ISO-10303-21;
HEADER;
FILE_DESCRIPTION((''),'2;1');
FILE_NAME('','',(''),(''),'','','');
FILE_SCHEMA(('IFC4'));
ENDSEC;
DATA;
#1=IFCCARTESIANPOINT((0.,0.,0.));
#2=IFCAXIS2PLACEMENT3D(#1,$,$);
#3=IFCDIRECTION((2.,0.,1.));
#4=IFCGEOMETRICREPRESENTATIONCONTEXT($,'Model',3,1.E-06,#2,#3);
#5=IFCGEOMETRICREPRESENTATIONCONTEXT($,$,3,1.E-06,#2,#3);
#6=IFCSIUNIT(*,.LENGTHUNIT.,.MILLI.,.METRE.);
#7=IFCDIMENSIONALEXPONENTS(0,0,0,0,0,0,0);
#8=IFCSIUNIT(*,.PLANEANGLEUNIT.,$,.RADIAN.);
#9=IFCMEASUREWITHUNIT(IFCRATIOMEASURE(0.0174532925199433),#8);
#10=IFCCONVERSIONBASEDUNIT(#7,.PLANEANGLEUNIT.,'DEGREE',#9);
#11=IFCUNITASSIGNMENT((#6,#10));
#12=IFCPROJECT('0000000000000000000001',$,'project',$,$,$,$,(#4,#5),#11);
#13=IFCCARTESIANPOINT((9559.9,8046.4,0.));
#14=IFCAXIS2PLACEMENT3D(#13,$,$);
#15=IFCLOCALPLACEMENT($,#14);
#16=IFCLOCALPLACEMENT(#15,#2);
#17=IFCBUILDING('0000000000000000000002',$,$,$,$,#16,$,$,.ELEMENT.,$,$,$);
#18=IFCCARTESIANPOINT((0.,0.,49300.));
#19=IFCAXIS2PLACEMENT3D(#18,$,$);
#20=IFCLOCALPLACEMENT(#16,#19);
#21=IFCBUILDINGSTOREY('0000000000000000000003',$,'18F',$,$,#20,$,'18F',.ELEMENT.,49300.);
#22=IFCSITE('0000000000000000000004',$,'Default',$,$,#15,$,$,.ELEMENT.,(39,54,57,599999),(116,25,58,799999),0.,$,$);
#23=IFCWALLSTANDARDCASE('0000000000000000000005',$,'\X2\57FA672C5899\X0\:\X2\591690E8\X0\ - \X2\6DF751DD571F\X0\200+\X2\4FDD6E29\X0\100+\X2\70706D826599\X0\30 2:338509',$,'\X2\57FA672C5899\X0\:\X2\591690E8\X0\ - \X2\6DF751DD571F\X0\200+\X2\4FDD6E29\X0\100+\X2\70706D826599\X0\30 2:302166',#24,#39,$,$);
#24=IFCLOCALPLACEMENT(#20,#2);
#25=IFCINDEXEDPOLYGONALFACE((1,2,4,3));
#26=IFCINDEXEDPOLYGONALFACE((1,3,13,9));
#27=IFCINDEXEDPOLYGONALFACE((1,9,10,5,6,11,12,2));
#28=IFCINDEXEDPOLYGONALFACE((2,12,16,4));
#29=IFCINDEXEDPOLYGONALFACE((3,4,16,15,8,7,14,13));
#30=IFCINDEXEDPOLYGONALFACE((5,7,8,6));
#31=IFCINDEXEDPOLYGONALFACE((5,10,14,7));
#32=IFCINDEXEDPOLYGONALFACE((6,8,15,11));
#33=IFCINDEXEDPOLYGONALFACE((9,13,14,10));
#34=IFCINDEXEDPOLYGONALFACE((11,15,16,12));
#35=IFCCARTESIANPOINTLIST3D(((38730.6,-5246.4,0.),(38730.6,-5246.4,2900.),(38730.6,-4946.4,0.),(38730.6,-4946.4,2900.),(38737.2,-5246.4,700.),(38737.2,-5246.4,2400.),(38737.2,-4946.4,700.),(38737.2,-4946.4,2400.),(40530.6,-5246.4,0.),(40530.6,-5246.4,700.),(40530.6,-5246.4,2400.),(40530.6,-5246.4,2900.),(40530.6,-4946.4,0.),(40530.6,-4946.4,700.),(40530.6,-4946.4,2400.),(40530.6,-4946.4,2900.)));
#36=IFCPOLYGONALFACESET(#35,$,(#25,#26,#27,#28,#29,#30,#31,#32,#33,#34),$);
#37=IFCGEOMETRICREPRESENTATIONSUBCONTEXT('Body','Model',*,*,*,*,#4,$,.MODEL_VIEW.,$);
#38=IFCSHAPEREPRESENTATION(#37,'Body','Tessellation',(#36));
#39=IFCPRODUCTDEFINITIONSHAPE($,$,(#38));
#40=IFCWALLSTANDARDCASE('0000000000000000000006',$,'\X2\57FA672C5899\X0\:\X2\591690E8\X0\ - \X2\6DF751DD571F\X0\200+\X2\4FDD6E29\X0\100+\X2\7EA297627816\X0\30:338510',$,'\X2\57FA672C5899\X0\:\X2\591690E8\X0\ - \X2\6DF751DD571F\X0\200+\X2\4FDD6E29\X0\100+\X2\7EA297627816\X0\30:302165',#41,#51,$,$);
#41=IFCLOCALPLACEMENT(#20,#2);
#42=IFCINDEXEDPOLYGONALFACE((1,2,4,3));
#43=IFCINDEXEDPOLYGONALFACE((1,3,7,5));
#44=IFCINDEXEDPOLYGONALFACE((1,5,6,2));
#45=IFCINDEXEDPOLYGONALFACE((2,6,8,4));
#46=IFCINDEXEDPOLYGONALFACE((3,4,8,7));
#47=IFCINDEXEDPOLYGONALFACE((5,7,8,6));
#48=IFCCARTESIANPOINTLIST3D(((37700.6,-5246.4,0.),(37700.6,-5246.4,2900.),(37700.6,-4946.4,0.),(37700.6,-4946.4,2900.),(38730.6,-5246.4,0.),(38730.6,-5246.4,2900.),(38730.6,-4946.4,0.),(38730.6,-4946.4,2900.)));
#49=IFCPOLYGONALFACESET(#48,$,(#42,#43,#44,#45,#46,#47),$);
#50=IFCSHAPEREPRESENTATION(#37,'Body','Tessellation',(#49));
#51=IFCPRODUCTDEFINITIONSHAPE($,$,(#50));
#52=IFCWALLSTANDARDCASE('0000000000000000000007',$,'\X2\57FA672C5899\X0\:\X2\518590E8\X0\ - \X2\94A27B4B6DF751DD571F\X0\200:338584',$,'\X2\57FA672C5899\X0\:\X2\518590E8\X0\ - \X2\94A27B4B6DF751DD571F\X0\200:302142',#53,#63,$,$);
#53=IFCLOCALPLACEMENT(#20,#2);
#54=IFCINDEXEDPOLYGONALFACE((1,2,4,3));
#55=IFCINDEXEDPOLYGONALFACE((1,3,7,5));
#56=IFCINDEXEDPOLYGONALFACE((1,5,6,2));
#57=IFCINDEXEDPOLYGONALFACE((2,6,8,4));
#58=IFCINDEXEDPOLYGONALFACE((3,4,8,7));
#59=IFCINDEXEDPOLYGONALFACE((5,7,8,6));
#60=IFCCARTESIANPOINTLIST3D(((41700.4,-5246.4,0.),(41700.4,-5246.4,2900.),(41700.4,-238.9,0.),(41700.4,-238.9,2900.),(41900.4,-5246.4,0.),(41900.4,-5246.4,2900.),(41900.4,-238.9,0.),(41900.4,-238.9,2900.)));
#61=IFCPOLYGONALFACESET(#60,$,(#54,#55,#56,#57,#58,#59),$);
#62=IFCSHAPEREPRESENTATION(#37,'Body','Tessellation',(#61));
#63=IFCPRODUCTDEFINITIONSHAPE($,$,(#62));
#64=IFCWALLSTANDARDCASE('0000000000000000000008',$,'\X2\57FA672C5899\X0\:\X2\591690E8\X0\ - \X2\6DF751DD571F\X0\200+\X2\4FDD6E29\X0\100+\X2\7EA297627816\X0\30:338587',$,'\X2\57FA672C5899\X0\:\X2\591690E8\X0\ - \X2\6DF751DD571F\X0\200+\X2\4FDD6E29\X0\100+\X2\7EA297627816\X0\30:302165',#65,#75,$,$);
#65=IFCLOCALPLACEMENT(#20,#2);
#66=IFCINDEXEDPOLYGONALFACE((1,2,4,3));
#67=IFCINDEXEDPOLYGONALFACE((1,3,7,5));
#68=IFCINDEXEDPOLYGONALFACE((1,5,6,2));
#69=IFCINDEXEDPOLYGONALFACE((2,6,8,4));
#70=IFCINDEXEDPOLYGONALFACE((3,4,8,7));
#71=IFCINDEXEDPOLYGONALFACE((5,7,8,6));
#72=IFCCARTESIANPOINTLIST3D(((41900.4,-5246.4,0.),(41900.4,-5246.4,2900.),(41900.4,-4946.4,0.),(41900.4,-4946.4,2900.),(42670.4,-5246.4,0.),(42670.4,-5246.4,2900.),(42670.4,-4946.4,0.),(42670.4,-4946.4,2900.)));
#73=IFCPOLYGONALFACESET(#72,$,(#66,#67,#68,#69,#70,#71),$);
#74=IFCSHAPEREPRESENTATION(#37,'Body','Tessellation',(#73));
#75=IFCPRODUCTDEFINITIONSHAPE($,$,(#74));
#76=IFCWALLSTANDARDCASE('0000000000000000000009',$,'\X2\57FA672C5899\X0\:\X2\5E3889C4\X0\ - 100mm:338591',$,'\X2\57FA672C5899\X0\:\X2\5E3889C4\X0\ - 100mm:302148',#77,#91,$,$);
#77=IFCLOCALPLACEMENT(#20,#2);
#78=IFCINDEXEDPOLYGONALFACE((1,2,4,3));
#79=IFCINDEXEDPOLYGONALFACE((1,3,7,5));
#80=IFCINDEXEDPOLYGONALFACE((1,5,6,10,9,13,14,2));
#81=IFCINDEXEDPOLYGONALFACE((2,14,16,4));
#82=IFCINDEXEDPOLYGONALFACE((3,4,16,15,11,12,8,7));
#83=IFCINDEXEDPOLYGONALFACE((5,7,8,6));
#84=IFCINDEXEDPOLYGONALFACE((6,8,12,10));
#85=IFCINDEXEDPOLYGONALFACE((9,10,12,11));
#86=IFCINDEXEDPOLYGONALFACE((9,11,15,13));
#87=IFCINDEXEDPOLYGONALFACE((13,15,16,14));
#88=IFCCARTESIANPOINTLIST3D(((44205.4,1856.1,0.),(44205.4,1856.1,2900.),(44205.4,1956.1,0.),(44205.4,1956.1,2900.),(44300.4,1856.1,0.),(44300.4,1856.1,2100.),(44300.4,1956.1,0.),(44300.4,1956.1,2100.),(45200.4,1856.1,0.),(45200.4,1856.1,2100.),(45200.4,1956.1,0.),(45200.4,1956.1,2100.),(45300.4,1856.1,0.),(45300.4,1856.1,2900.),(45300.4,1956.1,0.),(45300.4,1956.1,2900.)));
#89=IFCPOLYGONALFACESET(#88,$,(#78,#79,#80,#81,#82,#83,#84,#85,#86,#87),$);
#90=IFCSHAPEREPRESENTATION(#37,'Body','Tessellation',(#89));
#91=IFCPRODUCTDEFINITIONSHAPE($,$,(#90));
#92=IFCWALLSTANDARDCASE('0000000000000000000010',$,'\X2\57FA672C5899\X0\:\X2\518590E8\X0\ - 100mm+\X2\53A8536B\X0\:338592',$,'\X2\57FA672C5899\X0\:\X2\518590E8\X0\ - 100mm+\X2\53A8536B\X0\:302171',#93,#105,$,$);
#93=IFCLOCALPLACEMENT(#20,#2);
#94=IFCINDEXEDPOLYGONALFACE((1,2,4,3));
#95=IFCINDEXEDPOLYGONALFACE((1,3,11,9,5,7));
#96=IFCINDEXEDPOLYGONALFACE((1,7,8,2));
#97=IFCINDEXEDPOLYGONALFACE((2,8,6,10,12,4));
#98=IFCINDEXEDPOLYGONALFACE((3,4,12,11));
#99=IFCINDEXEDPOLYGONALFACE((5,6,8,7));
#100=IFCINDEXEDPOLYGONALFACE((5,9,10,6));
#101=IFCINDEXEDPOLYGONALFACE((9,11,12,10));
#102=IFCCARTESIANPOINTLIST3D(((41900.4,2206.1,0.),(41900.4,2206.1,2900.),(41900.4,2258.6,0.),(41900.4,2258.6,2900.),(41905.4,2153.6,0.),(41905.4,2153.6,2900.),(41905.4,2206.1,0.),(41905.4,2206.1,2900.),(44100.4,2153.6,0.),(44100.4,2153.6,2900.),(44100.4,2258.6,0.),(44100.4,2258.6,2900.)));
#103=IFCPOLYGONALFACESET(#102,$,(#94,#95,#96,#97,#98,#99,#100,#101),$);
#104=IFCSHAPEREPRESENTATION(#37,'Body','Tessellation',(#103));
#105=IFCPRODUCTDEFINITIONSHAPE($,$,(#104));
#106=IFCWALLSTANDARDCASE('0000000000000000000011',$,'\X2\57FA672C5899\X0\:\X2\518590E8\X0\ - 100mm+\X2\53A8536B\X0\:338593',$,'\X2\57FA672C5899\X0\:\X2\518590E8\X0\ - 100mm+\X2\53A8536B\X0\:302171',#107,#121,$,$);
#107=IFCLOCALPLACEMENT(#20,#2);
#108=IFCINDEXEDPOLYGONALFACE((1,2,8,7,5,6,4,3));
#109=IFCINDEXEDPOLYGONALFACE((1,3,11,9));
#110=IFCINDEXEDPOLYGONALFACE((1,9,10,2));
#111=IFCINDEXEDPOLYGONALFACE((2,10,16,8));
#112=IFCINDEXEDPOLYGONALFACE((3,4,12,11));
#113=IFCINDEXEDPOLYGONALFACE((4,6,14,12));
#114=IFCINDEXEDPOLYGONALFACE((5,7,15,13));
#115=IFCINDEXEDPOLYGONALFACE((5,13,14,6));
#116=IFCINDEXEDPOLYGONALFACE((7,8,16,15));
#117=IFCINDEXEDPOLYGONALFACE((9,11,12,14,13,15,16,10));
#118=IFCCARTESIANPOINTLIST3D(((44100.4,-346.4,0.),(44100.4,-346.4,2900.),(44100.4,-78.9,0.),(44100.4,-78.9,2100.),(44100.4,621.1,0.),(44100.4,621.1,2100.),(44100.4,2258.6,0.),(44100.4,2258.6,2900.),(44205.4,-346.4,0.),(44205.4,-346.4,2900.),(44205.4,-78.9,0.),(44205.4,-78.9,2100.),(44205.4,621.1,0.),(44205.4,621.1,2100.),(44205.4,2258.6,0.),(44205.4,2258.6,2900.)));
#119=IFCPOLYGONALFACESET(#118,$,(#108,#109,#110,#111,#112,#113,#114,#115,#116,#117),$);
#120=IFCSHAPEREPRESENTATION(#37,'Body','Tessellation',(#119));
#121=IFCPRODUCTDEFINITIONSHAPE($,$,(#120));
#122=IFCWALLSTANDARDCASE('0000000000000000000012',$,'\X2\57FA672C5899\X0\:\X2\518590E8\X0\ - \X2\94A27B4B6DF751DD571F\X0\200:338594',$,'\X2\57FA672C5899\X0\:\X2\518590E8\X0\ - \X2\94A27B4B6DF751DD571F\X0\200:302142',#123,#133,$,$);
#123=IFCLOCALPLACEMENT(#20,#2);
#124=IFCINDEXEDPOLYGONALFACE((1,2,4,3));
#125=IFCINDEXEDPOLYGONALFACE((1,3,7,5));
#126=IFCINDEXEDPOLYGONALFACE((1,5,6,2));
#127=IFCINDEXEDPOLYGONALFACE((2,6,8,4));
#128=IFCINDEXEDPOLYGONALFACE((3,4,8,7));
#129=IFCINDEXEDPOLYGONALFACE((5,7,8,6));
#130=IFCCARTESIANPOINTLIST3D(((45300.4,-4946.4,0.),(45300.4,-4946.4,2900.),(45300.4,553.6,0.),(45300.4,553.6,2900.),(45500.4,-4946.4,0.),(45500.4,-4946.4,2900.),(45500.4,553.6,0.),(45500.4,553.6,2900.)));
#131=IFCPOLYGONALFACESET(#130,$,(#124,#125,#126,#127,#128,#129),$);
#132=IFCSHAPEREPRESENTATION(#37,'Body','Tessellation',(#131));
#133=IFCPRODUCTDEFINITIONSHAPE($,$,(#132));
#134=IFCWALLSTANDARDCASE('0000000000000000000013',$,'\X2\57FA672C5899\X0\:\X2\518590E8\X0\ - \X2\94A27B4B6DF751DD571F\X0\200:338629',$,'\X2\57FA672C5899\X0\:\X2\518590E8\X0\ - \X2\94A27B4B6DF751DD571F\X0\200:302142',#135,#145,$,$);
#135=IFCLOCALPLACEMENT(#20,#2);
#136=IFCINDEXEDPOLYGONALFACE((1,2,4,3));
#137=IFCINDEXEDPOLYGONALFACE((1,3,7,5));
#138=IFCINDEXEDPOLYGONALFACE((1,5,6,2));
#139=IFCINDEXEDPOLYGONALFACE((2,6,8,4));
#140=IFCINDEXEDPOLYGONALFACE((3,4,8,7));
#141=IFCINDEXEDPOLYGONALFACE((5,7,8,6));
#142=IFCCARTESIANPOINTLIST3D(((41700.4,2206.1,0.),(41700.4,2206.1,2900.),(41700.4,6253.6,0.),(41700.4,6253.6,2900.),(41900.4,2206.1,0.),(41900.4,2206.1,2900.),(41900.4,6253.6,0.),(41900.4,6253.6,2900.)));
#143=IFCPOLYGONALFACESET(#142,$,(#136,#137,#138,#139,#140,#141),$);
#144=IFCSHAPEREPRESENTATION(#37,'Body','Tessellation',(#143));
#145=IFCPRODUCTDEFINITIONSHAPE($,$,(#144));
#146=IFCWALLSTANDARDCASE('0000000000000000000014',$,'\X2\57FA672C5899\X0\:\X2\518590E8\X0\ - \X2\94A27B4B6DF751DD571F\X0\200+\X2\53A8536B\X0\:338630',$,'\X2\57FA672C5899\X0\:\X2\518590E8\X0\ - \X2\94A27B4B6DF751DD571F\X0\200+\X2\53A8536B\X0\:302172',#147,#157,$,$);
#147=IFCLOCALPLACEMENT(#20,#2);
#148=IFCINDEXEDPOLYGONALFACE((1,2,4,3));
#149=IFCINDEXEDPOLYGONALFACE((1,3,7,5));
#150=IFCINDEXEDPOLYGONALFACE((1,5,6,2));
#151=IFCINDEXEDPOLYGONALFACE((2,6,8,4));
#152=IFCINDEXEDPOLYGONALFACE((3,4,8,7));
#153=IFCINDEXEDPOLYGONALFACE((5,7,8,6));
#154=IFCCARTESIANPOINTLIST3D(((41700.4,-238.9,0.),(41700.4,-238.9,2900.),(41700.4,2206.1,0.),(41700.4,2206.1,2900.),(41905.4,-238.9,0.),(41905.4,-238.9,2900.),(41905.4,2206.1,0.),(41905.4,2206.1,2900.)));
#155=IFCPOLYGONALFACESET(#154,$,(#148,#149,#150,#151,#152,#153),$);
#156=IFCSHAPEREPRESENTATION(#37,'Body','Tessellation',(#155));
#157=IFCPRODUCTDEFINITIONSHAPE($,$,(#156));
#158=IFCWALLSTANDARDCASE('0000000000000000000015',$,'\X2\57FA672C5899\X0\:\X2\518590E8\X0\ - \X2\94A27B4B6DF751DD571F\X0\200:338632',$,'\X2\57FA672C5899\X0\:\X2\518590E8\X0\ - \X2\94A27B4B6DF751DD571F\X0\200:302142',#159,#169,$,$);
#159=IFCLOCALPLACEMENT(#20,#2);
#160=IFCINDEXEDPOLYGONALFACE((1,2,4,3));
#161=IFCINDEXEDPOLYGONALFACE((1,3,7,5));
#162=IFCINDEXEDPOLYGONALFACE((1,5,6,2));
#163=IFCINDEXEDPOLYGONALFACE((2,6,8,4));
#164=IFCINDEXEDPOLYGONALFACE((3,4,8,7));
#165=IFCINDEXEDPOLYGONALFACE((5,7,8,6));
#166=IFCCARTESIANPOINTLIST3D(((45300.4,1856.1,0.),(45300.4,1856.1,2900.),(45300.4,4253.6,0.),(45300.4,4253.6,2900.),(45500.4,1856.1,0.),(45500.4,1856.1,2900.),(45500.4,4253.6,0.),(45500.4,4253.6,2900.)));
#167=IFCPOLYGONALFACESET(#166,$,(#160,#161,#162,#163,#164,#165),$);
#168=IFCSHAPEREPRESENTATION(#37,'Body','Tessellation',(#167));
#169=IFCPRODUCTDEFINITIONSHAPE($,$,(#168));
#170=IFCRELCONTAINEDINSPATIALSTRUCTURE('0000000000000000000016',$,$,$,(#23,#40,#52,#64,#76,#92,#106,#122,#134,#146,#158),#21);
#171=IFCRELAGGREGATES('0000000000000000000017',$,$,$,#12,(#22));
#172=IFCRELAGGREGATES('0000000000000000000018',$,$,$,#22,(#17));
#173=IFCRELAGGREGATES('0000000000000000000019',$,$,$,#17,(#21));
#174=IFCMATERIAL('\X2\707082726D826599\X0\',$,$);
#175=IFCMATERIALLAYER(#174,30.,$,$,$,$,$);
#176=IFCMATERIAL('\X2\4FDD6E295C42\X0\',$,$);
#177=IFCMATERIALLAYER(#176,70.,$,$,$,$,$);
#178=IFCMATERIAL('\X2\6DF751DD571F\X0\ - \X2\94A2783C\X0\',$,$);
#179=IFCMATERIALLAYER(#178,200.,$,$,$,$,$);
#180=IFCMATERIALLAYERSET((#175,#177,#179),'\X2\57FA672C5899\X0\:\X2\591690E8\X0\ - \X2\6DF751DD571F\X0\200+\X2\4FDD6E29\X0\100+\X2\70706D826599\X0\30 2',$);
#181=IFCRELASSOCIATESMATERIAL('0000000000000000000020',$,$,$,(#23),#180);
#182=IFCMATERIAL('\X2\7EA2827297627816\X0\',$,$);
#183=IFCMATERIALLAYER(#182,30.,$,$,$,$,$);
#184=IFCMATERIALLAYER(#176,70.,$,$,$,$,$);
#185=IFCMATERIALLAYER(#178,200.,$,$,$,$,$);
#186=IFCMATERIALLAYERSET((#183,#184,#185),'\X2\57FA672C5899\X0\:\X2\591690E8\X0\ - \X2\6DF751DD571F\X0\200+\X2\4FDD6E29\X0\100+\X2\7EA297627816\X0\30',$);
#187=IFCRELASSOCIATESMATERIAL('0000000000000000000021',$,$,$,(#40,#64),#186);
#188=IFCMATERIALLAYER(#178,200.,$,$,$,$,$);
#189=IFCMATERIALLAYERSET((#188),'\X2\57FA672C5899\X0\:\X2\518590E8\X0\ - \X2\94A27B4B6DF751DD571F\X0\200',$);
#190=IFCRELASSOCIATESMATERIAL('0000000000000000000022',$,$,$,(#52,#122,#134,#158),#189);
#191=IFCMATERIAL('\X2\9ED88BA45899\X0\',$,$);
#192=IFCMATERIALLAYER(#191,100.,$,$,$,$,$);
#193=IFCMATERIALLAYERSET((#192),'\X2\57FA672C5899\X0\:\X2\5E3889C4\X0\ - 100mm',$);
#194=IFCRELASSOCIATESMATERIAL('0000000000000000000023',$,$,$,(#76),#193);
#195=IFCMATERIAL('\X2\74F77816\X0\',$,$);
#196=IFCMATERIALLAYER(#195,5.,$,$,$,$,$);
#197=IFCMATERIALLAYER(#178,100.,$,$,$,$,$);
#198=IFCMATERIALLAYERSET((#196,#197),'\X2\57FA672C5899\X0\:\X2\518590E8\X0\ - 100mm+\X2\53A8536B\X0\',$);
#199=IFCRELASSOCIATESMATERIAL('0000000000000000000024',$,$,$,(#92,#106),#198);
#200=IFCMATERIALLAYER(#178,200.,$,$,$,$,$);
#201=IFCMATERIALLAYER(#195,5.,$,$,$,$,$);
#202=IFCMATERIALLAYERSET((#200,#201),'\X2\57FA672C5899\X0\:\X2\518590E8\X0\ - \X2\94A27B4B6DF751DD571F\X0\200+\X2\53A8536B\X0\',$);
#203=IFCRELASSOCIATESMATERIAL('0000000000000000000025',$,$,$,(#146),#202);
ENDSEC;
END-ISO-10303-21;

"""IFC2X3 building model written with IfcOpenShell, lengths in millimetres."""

from ifc_helpers import new_model, entity, si_unit, converted_unit, direction, frame, frame_2d, origin, place, context, subcontext, project, spatial, polyline, rectangle, outline, extrude, material, layer, layer_set, layer_usage, element, save


model = new_model("IFC2X3")

# Units and contexts
model_context = context("Model", 3, precision=1e-06, world=origin(), true_north=direction((2.0, 0.0, 1.0)))
context_of_model = context(None, 3, precision=1e-06, world=origin(), true_north=direction((2.0, 0.0, 1.0)))
body_context = subcontext(model_context, "Body", "Model", "MODEL_VIEW")
ifc_project = project(units=[si_unit("LENGTHUNIT", "METRE", prefix="MILLI"), converted_unit("PLANEANGLEUNIT", "DEGREE", entity("IfcRatioMeasure", 0.0174532925199433), si_unit("PLANEANGLEUNIT", "RADIAN"), dimensions=[0, 0, 0, 0, 0, 0, 0])], contexts=[model_context, context_of_model])

# Site, building, storey
site_placement = place(None, frame((9559.9, 8046.4, 0.0)))
site = spatial("IfcSite", under=ifc_project, at=site_placement, Name="Default", CompositionType="ELEMENT", RefLatitude=(39, 54, 57, 599999), RefLongitude=(116, 25, 58, 799999), RefElevation=0.0)
building_placement = place(site_placement, origin())
building = spatial("IfcBuilding", under=site, at=building_placement, CompositionType="ELEMENT")
storey_placement = place(building_placement, frame((0.0, 0.0, 49300.0)))
storey = spatial("IfcBuildingStorey", under=building, at=storey_placement, Name="18F", LongName="18F", CompositionType="ELEMENT", Elevation=49300.0)

# Shared definitions
ifc_material_1 = material(Name="混凝土 - 钢砼")
ifc_layer_1 = layer(ifc_material_1, 200.0)
ifc_layer_set_1 = layer_set([ifc_layer_1], Name="基本墙:内部 - 钢筋混凝土200")
ifc_material_2 = material(Name="红色面砖")
ifc_layer_2 = layer(ifc_material_2, 30.0)
ifc_material_3 = material(Name="保温层")
ifc_layer_3 = layer(ifc_material_3, 70.0)
ifc_layer_4 = layer(ifc_material_1, 200.0)
ifc_layer_set_2 = layer_set([ifc_layer_2, ifc_layer_3, ifc_layer_4], Name="基本墙:外部 - 混凝土200+保温100+红面砖30")

# Shared definitions
ifc_material_4 = material(Name="默认墙")
ifc_layer_5 = layer(ifc_material_4, 100.0)
ifc_layer_set_3 = layer_set([ifc_layer_5], Name="基本墙:常规 - 100mm")

# Shared definitions
ifc_material_5 = material(Name="瓷砖")
ifc_layer_6 = layer(ifc_material_5, 5.0)
ifc_layer_7 = layer(ifc_material_1, 100.0)
ifc_layer_set_4 = layer_set([ifc_layer_6, ifc_layer_7], Name="基本墙:内部 - 100mm+厨卫")

# Shared definitions
ifc_layer_8 = layer(ifc_material_1, 200.0)
ifc_layer_9 = layer(ifc_material_5, 5.0)
ifc_layer_set_5 = layer_set([ifc_layer_8, ifc_layer_9], Name="基本墙:内部 - 钢筋混凝土200+厨卫")

# Wall, opening
ifc_material_6 = material(Name="灰色涂料")
ifc_layer_10 = layer(ifc_material_6, 30.0)
ifc_layer_11 = layer(ifc_material_3, 70.0)
ifc_layer_12 = layer(ifc_material_1, 200.0)
ifc_layer_set_6 = layer_set([ifc_layer_10, ifc_layer_11, ifc_layer_12], Name="基本墙:外部 - 混凝土200+保温100+灰涂料30 2")
ifc_layer_usage_1 = layer_usage(ifc_layer_set_6, "AXIS2", "NEGATIVE", 150.0)
wall_1_placement = place(storey_placement, frame((40530.6, -5096.4, 0.0), z_axis=(0.0, 0.0, 1.0), x_axis=(-1.0, 0.0, 0.0)))
wall_1 = element("IfcWallStandardCase", 1, at=wall_1_placement, inside=storey, material=ifc_layer_usage_1, Name="基本墙:外部 - 混凝土200+保温100+灰涂料30 2:338509", ObjectType="基本墙:外部 - 混凝土200+保温100+灰涂料30 2:302166", context=body_context, shape_type="SweptSolid", body=[
    extrude(rectangle(XDim=1800.0, YDim=300.0, at=frame_2d((900.0, 0.0), x_axis=(-1.0, 0.0))), origin(), (0.0, 0.0, 1.0), 2900.0),
])
opening_1_placement = place(wall_1_placement, frame((-6.6, -150.0, 700.0)))
element("IfcOpeningElement", 2, at=opening_1_placement, cuts=wall_1, ObjectType="Opening", context=body_context, shape_type="SweptSolid", body=[
    extrude(rectangle(XDim=1700.0, YDim=1800.0, at=frame_2d((850.0, 900.0), x_axis=(1.0, 0.0))), frame((0.0, 0.0, 0.0), z_axis=(0.0, 1.0, 0.0), x_axis=(0.0, 0.0, 1.0)), (0.0, 0.0, 1.0), 300.0),
])

# Walls
ifc_layer_usage_2 = layer_usage(ifc_layer_set_2, "AXIS2", "NEGATIVE", 150.0)
wall_2_placement = place(storey_placement, frame((38730.6, -5096.4, 0.0), z_axis=(0.0, 0.0, 1.0), x_axis=(-1.0, 0.0, 0.0)))
element("IfcWallStandardCase", 3, at=wall_2_placement, inside=storey, material=ifc_layer_usage_2, Name="基本墙:外部 - 混凝土200+保温100+红面砖30:338510", ObjectType="基本墙:外部 - 混凝土200+保温100+红面砖30:302165", context=body_context, shape_type="SweptSolid", body=[
    extrude(rectangle(XDim=1030.0, YDim=300.0, at=frame_2d((515.0, 0.0), x_axis=(-1.0, 0.0))), origin(), (0.0, 0.0, 1.0), 2900.0),
])
ifc_layer_usage_3 = layer_usage(ifc_layer_set_1, "AXIS2", "NEGATIVE", 100.0)
wall_3_placement = place(storey_placement, frame((41800.4, -5246.4, 0.0), z_axis=(0.0, 0.0, 1.0), x_axis=(0.0, 1.0, 0.0)))
element("IfcWallStandardCase", 4, at=wall_3_placement, inside=storey, material=ifc_layer_usage_3, Name="基本墙:内部 - 钢筋混凝土200:338584", ObjectType="基本墙:内部 - 钢筋混凝土200:302142", context=body_context, shape_type="SweptSolid", body=[
    extrude(rectangle(XDim=5007.5, YDim=200.0, at=frame_2d((2503.8, 0.0), x_axis=(-1.0, 0.0))), origin(), (0.0, 0.0, 1.0), 2900.0),
])
ifc_layer_usage_4 = layer_usage(ifc_layer_set_2, "AXIS2", "POSITIVE", -150.0)
wall_4_placement = place(storey_placement, frame((41900.4, -5096.4, 0.0)))
element("IfcWallStandardCase", 5, at=wall_4_placement, inside=storey, material=ifc_layer_usage_4, Name="基本墙:外部 - 混凝土200+保温100+红面砖30:338587", ObjectType="基本墙:外部 - 混凝土200+保温100+红面砖30:302165", context=body_context, shape_type="SweptSolid", body=[
    extrude(rectangle(XDim=770.0, YDim=300.0, at=frame_2d((385.0, 0.0), x_axis=(-1.0, 0.0))), origin(), (0.0, 0.0, 1.0), 2900.0),
])

# Wall, opening
ifc_layer_usage_5 = layer_usage(ifc_layer_set_3, "AXIS2", "NEGATIVE", 50.0)
wall_5_placement = place(storey_placement, frame((44205.4, 1906.1, 0.0)))
wall_5 = element("IfcWallStandardCase", 6, at=wall_5_placement, inside=storey, material=ifc_layer_usage_5, Name="基本墙:常规 - 100mm:338591", ObjectType="基本墙:常规 - 100mm:302148", context=body_context, shape_type="SweptSolid", body=[
    extrude(rectangle(XDim=1095.0, YDim=100.0, at=frame_2d((547.5, 0.0), x_axis=(-1.0, 0.0))), origin(), (0.0, 0.0, 1.0), 2900.0),
])
opening_2_placement = place(wall_5_placement, frame((95.0, -50.0, 0.0)))
element("IfcOpeningElement", 7, at=opening_2_placement, cuts=wall_5, ObjectType="Opening", context=body_context, shape_type="SweptSolid", body=[
    extrude(rectangle(XDim=2100.0, YDim=900.0, at=frame_2d((1050.0, 450.0), x_axis=(1.0, 0.0))), frame((0.0, 0.0, 0.0), z_axis=(0.0, 1.0, 0.0), x_axis=(0.0, 0.0, 1.0)), (0.0, 0.0, 1.0), 100.0),
])

# Wall
ifc_layer_usage_6 = layer_usage(ifc_layer_set_4, "AXIS2", "POSITIVE", -52.5)
wall_6_placement = place(storey_placement, frame((41900.4, 2206.1, 0.0)))
element("IfcWallStandardCase", 8, at=wall_6_placement, inside=storey, material=ifc_layer_usage_6, Name="基本墙:内部 - 100mm+厨卫:338592", ObjectType="基本墙:内部 - 100mm+厨卫:302171", context=body_context, shape_type="SweptSolid", body=[
    extrude(outline(polyline([(2200.0, -52.5), (2200.0, 52.5), (0.0, 52.5), (0.0, 0.0), (5.0, 0.0), (5.0, -52.5), (2200.0, -52.5)])), origin(), (0.0, 0.0, 1.0), 2900.0),
])

# Wall, opening
ifc_layer_usage_7 = layer_usage(ifc_layer_set_4, "AXIS2", "POSITIVE", -52.5)
wall_7_placement = place(storey_placement, frame((44152.9, 2258.6, 0.0), z_axis=(0.0, 0.0, 1.0), x_axis=(0.0, -1.0, 0.0)))
wall_7 = element("IfcWallStandardCase", 9, at=wall_7_placement, inside=storey, material=ifc_layer_usage_7, Name="基本墙:内部 - 100mm+厨卫:338593", ObjectType="基本墙:内部 - 100mm+厨卫:302171", context=body_context, shape_type="SweptSolid", body=[
    extrude(rectangle(XDim=2605.0, YDim=105.0, at=frame_2d((1302.5, 0.0), x_axis=(-1.0, 0.0))), origin(), (0.0, 0.0, 1.0), 2900.0),
])
opening_3_placement = place(wall_7_placement, frame((2337.5, 52.5, 0.0)))
element("IfcOpeningElement", 10, at=opening_3_placement, cuts=wall_7, ObjectType="Opening", context=body_context, shape_type="SweptSolid", body=[
    extrude(rectangle(XDim=2100.0, YDim=700.0, at=frame_2d((1050.0, 350.0), x_axis=(1.0, 0.0))), frame((0.0, 0.0, 0.0), z_axis=(0.0, -1.0, 0.0), x_axis=(0.0, 0.0, 1.0)), (0.0, 0.0, 1.0), 105.0),
])

# Walls
ifc_layer_usage_8 = layer_usage(ifc_layer_set_1, "AXIS2", "POSITIVE", -100.0)
wall_8_placement = place(storey_placement, frame((45400.4, 553.6, 0.0), z_axis=(0.0, 0.0, 1.0), x_axis=(0.0, -1.0, 0.0)))
element("IfcWallStandardCase", 11, at=wall_8_placement, inside=storey, material=ifc_layer_usage_8, Name="基本墙:内部 - 钢筋混凝土200:338594", ObjectType="基本墙:内部 - 钢筋混凝土200:302142", context=body_context, shape_type="SweptSolid", body=[
    extrude(rectangle(XDim=5500.0, YDim=200.0, at=frame_2d((2750.0, 0.0), x_axis=(-1.0, 0.0))), origin(), (0.0, 0.0, 1.0), 2900.0),
])
ifc_layer_usage_9 = layer_usage(ifc_layer_set_1, "AXIS2", "NEGATIVE", 100.0)
wall_9_placement = place(storey_placement, frame((41800.4, 2206.1, 0.0), z_axis=(0.0, 0.0, 1.0), x_axis=(0.0, 1.0, 0.0)))
element("IfcWallStandardCase", 12, at=wall_9_placement, inside=storey, material=ifc_layer_usage_9, Name="基本墙:内部 - 钢筋混凝土200:338629", ObjectType="基本墙:内部 - 钢筋混凝土200:302142", context=body_context, shape_type="SweptSolid", body=[
    extrude(rectangle(XDim=4047.5, YDim=200.0, at=frame_2d((2023.8, 0.0), x_axis=(-1.0, 0.0))), origin(), (0.0, 0.0, 1.0), 2900.0),
])
ifc_layer_usage_10 = layer_usage(ifc_layer_set_5, "AXIS2", "NEGATIVE", 102.5)
wall_10_placement = place(storey_placement, frame((41802.9, -238.9, 0.0), z_axis=(0.0, 0.0, 1.0), x_axis=(0.0, 1.0, 0.0)))
element("IfcWallStandardCase", 13, at=wall_10_placement, inside=storey, material=ifc_layer_usage_10, Name="基本墙:内部 - 钢筋混凝土200+厨卫:338630", ObjectType="基本墙:内部 - 钢筋混凝土200+厨卫:302172", context=body_context, shape_type="SweptSolid", body=[
    extrude(rectangle(XDim=2445.0, YDim=205.0, at=frame_2d((1222.5, 0.0), x_axis=(-1.0, 0.0))), origin(), (0.0, 0.0, 1.0), 2900.0),
])
ifc_layer_usage_11 = layer_usage(ifc_layer_set_1, "AXIS2", "NEGATIVE", 100.0)
wall_11_placement = place(storey_placement, frame((45400.4, 4253.6, 0.0), z_axis=(0.0, 0.0, 1.0), x_axis=(0.0, -1.0, 0.0)))
element("IfcWallStandardCase", 14, at=wall_11_placement, inside=storey, material=ifc_layer_usage_11, Name="基本墙:内部 - 钢筋混凝土200:338632", ObjectType="基本墙:内部 - 钢筋混凝土200:302142", context=body_context, shape_type="SweptSolid", body=[
    extrude(rectangle(XDim=2397.5, YDim=200.0, at=frame_2d((1198.8, 0.0), x_axis=(-1.0, 0.0))), origin(), (0.0, 0.0, 1.0), 2900.0),
])

save(model, "model.ifc")
